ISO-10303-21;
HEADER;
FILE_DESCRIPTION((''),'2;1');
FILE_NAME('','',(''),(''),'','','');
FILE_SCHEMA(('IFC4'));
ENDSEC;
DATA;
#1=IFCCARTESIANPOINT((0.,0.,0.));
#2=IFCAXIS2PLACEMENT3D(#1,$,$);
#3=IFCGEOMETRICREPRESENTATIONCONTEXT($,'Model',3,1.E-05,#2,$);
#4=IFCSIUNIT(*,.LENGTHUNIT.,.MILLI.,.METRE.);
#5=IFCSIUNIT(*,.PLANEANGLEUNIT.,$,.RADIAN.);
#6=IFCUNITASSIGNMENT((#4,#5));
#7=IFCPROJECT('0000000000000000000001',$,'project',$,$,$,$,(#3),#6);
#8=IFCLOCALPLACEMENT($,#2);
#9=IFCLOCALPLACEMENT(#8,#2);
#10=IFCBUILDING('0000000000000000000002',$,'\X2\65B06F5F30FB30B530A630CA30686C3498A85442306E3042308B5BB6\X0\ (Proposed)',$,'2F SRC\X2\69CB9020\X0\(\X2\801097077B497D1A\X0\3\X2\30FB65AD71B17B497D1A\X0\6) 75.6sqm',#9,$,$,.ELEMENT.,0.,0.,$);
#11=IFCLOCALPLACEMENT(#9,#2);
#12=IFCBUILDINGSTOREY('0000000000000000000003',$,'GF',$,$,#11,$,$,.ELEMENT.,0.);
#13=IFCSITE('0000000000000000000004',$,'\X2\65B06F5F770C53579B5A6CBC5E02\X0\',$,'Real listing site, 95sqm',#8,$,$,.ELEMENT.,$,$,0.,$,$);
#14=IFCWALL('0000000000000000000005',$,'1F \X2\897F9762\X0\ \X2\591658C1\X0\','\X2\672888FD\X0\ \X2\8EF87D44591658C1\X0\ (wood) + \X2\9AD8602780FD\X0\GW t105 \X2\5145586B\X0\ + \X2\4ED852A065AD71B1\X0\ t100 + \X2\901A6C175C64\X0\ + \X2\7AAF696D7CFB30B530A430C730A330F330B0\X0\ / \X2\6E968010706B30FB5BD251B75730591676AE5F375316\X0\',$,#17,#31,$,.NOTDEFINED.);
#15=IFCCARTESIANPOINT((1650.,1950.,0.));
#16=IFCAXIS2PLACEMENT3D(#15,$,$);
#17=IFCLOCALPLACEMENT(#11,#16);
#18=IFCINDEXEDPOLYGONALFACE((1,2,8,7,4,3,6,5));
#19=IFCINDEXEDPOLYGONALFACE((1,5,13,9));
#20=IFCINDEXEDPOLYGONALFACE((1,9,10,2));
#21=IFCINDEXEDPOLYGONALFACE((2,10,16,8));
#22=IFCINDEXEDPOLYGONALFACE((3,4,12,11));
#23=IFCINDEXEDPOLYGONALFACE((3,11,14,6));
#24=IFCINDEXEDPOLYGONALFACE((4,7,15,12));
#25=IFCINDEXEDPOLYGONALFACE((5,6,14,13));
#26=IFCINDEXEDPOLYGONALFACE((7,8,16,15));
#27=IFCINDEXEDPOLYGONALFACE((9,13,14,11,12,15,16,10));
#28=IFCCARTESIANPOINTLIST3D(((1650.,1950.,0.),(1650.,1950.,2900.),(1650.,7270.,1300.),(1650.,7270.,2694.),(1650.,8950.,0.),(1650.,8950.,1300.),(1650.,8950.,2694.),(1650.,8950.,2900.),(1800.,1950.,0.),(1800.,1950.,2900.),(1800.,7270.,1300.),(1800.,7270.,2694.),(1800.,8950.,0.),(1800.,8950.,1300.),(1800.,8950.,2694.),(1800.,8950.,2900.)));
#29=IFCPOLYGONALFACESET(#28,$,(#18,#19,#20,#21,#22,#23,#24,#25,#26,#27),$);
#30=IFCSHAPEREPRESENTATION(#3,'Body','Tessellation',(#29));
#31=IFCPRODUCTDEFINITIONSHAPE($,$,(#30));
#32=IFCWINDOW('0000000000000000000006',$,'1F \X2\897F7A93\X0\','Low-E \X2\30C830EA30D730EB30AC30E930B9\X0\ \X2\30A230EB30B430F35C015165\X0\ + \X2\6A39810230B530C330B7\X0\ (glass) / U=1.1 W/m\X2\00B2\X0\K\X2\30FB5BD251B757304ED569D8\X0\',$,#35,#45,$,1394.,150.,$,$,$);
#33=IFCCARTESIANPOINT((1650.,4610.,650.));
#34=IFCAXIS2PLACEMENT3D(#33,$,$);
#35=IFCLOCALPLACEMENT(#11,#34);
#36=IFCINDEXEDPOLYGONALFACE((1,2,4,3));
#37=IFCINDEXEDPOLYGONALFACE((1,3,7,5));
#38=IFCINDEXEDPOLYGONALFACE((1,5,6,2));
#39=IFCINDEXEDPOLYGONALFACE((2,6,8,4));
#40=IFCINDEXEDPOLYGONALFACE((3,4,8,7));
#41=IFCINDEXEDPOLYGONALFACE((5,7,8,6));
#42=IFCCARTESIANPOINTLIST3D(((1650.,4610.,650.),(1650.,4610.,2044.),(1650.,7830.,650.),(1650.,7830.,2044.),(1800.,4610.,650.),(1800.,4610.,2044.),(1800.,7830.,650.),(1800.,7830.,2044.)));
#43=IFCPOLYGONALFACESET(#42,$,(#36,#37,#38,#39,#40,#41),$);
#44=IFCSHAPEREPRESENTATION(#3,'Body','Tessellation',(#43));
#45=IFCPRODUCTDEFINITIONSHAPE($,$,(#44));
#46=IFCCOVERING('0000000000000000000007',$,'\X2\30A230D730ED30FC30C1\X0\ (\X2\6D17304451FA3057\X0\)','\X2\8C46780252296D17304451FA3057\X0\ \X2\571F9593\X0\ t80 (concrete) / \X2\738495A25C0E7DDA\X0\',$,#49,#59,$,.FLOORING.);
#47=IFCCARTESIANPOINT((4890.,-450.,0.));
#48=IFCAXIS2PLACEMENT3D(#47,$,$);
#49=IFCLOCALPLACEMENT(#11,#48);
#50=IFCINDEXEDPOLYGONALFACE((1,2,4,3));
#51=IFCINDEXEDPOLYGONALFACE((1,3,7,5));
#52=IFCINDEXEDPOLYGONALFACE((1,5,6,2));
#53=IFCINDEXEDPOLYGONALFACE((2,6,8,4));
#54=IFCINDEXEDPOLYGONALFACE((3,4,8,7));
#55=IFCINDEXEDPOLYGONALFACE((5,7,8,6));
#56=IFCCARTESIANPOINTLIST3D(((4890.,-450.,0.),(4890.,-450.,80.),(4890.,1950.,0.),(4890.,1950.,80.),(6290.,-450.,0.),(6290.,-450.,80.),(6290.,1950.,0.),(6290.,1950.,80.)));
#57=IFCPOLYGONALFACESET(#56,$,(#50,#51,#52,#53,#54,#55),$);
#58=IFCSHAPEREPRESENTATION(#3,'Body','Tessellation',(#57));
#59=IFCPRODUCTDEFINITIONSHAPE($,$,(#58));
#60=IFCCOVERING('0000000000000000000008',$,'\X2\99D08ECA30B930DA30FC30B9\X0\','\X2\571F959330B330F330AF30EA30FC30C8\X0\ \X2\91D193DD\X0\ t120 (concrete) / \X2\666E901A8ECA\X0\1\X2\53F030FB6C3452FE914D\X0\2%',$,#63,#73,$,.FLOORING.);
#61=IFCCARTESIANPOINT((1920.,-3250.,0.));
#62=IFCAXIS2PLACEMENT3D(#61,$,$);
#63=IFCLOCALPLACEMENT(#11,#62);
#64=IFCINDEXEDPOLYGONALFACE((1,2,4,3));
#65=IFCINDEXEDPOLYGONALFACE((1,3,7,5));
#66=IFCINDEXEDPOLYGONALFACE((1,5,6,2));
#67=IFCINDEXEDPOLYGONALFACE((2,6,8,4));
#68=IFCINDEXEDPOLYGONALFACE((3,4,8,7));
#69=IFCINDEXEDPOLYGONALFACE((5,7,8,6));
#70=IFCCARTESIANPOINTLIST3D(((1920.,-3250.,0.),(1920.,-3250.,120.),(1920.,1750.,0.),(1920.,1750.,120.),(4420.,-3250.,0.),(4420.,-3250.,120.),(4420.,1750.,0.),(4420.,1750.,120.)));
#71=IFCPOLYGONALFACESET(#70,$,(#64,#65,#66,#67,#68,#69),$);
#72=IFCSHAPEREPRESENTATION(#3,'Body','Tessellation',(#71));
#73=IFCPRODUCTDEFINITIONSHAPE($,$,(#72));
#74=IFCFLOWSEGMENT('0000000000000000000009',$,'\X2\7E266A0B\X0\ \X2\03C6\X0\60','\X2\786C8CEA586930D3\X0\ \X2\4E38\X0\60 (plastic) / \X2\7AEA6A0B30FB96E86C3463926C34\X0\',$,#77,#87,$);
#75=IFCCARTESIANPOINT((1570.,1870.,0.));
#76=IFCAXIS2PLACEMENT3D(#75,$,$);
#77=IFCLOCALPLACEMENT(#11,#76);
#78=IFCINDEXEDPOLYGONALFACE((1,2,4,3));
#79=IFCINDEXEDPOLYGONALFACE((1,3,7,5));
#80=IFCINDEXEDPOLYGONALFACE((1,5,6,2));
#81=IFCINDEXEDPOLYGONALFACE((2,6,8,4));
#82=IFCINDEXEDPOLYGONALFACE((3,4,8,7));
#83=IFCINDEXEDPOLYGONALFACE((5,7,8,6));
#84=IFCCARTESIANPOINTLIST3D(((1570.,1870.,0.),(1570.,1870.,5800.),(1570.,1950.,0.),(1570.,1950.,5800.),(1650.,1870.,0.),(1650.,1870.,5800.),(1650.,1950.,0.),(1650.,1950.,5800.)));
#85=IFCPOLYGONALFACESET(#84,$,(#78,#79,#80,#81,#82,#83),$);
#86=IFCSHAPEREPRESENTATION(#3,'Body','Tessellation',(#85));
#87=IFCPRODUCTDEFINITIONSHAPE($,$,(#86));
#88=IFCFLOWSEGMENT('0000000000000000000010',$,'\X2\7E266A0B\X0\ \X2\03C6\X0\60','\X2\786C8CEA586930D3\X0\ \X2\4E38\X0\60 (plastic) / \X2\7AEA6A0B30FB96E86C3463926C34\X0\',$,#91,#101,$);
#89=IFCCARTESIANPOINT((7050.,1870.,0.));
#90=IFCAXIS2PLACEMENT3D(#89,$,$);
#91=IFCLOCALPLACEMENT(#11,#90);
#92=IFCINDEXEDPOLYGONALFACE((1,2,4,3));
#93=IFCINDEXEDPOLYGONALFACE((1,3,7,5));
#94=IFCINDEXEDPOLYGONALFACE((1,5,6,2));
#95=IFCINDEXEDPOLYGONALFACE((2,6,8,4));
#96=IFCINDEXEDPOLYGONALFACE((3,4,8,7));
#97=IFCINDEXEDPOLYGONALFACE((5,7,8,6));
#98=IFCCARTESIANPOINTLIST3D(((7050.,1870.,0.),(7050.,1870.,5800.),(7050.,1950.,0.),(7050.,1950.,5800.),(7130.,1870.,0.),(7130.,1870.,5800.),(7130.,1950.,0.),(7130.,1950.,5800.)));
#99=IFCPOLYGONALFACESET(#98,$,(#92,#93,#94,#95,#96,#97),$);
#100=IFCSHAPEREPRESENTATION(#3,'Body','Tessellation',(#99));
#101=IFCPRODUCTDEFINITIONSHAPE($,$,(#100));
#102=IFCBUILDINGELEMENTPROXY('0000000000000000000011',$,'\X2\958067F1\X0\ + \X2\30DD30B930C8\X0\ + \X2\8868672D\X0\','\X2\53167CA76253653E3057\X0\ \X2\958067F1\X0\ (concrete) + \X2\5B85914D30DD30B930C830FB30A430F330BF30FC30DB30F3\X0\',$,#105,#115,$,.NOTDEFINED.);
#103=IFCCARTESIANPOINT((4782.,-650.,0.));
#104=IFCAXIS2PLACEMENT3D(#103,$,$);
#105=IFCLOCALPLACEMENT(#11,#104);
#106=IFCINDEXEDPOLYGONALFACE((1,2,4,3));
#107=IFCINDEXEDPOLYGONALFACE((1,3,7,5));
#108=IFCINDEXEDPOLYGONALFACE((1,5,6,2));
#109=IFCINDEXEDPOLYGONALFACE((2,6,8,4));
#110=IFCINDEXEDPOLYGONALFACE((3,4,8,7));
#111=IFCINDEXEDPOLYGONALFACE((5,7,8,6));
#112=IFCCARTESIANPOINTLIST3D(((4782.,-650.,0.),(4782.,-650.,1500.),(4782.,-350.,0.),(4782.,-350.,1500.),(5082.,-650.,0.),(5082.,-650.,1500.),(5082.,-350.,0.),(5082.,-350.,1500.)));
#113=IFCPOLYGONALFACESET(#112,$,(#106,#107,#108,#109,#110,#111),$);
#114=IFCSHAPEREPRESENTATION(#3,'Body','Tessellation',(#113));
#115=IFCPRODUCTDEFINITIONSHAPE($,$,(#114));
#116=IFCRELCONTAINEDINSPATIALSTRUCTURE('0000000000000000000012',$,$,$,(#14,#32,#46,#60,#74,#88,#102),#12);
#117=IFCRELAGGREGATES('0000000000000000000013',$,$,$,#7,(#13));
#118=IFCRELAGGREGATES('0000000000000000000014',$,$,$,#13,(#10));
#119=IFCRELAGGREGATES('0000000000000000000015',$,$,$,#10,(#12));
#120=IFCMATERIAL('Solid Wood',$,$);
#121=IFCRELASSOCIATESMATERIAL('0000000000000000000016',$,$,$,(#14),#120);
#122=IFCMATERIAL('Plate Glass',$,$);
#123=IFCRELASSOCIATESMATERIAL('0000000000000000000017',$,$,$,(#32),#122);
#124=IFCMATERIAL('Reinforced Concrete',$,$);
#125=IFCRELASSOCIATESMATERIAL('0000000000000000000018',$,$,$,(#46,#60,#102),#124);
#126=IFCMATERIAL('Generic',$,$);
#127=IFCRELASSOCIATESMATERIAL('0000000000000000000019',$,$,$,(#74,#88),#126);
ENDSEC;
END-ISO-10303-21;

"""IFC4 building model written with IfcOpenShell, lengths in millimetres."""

from ifc_helpers import new_model, si_unit, frame, frame_2d, origin, place, context, project, spatial, rectangle, extrude, material, element, fill, save


model = new_model("IFC4")

# Units and contexts
model_context = context("Model", 3, precision=1e-05, world=origin())
ifc_project = project(units=[si_unit("LENGTHUNIT", "METRE", prefix="MILLI"), si_unit("PLANEANGLEUNIT", "RADIAN")], contexts=[model_context])

# Site, building, storey
site_placement = place(None, origin())
site = spatial("IfcSite", under=ifc_project, at=site_placement, Name="新潟県南魚沼市", ObjectType="Real listing site, 95sqm", CompositionType="ELEMENT", RefElevation=0.0)
building_placement = place(site_placement, origin())
building = spatial("IfcBuilding", under=site, at=building_placement, Name="新潟・サウナと水風呂のある家 (Proposed)", ObjectType="2F SRC構造(耐震等級3・断熱等級6) 75.6sqm", CompositionType="ELEMENT", ElevationOfRefHeight=0.0, ElevationOfTerrain=0.0)
storey_placement = place(building_placement, origin())
storey = spatial("IfcBuildingStorey", under=building, at=storey_placement, Name="GF", CompositionType="ELEMENT", Elevation=0.0)

# Shared definitions
ifc_material_1 = material(Name="Solid Wood")

# Shared definitions
ifc_material_2 = material(Name="Reinforced Concrete")

# Shared definitions
ifc_material_3 = material(Name="Plate Glass")

# Wall, opening, window
wall_1_placement = place(storey_placement, frame((1650.0, 1950.0, 0.0)))
wall_1 = element("IfcWall", 1, at=wall_1_placement, inside=storey, material=ifc_material_1, Name="1F 西面 外壁", Description="木製 軸組外壁 (wood) + 高性能GW t105 充填 + 付加断熱 t100 + 通気層 + 窯業系サイディング / 準耐火・寒冷地外皮強化", PredefinedType="NOTDEFINED", context=model_context, shape_type="SweptSolid", body=[
    extrude(rectangle(XDim=150.0, YDim=7000.0, at=frame_2d((75.0, 3500.0))), frame((1650.0, 1950.0, 0.0)), (0.0, 0.0, 1.0), 2900.0),
])
opening_1_placement = place(storey_placement, frame((1650.0, 4610.0, 650.0)))
opening_1 = element("IfcOpeningElement", 2, at=opening_1_placement, cuts=wall_1, PredefinedType="NOTDEFINED", context=model_context, shape_type="SweptSolid", body=[
    extrude(rectangle(XDim=150.0, YDim=3220.0, at=frame_2d((75.0, 1610.0))), frame((1650.0, 4610.0, 650.0)), (0.0, 0.0, 1.0), 1394.0),
])
window_1_placement = place(storey_placement, frame((1650.0, 4610.0, 650.0)))
window_1 = element("IfcWindow", 3, at=window_1_placement, inside=storey, material=ifc_material_3, Name="1F 西窓", Description="Low-E トリプルガラス アルゴン封入 + 樹脂サッシ (glass) / U=1.1 W/m²K・寒冷地仕様", OverallHeight=1394.0, OverallWidth=150.0, context=model_context, shape_type="SweptSolid", body=[
    extrude(rectangle(XDim=150.0, YDim=3220.0, at=frame_2d((75.0, 1610.0))), frame((1650.0, 4610.0, 650.0)), (0.0, 0.0, 1.0), 1394.0),
])
fill(opening_1, window_1)

# Coverings
covering_1_placement = place(storey_placement, frame((4890.0, -450.0, 0.0)))
element("IfcCovering", 4, at=covering_1_placement, inside=storey, material=ifc_material_2, Name="アプローチ (洗い出し)", Description="豆砂利洗い出し 土間 t80 (concrete) / 玄関導線", PredefinedType="FLOORING", context=model_context, shape_type="SweptSolid", body=[
    extrude(rectangle(XDim=1400.0, YDim=2400.0, at=frame_2d((700.0, 1200.0))), frame((4890.0, -450.0, 0.0)), (0.0, 0.0, 1.0), 80.0),
])
covering_2_placement = place(storey_placement, frame((1920.0, -3250.0, 0.0)))
element("IfcCovering", 5, at=covering_2_placement, inside=storey, material=ifc_material_2, Name="駐車スペース", Description="土間コンクリート 金鏝 t120 (concrete) / 普通車1台・水勾配2%", PredefinedType="FLOORING", context=model_context, shape_type="SweptSolid", body=[
    extrude(rectangle(XDim=2500.0, YDim=5000.0, at=frame_2d((1250.0, 2500.0))), frame((1920.0, -3250.0, 0.0)), (0.0, 0.0, 1.0), 120.0),
])

# Flow segments
ifc_material_4 = material(Name="Generic")
flow_segment_1_placement = place(storey_placement, frame((1570.0, 1870.0, 0.0)))
element("IfcFlowSegment", 6, at=flow_segment_1_placement, inside=storey, material=ifc_material_4, Name="縦樋 φ60", Description="硬質塩ビ 丸60 (plastic) / 竪樋・雨水排水", context=model_context, shape_type="SweptSolid", body=[
    extrude(rectangle(XDim=80.0, YDim=80.0, at=frame_2d((40.0, 40.0))), frame((1570.0, 1870.0, 0.0)), (0.0, 0.0, 1.0), 5800.0),
])
flow_segment_2_placement = place(storey_placement, frame((7050.0, 1870.0, 0.0)))
element("IfcFlowSegment", 7, at=flow_segment_2_placement, inside=storey, material=ifc_material_4, Name="縦樋 φ60", Description="硬質塩ビ 丸60 (plastic) / 竪樋・雨水排水", context=model_context, shape_type="SweptSolid", body=[
    extrude(rectangle(XDim=80.0, YDim=80.0, at=frame_2d((40.0, 40.0))), frame((7050.0, 1870.0, 0.0)), (0.0, 0.0, 1.0), 5800.0),
])

# Building element proxy
proxy_placement = place(storey_placement, frame((4782.0, -650.0, 0.0)))
element("IfcBuildingElementProxy", 8, at=proxy_placement, inside=storey, material=ifc_material_2, Name="門柱 + ポスト + 表札", Description="化粧打放し 門柱 (concrete) + 宅配ポスト・インターホン", PredefinedType="NOTDEFINED", context=model_context, shape_type="SweptSolid", body=[
    extrude(rectangle(XDim=300.0, YDim=300.0, at=frame_2d((150.0, 150.0))), frame((4782.0, -650.0, 0.0)), (0.0, 0.0, 1.0), 1500.0),
])

save(model, "model.ifc")
